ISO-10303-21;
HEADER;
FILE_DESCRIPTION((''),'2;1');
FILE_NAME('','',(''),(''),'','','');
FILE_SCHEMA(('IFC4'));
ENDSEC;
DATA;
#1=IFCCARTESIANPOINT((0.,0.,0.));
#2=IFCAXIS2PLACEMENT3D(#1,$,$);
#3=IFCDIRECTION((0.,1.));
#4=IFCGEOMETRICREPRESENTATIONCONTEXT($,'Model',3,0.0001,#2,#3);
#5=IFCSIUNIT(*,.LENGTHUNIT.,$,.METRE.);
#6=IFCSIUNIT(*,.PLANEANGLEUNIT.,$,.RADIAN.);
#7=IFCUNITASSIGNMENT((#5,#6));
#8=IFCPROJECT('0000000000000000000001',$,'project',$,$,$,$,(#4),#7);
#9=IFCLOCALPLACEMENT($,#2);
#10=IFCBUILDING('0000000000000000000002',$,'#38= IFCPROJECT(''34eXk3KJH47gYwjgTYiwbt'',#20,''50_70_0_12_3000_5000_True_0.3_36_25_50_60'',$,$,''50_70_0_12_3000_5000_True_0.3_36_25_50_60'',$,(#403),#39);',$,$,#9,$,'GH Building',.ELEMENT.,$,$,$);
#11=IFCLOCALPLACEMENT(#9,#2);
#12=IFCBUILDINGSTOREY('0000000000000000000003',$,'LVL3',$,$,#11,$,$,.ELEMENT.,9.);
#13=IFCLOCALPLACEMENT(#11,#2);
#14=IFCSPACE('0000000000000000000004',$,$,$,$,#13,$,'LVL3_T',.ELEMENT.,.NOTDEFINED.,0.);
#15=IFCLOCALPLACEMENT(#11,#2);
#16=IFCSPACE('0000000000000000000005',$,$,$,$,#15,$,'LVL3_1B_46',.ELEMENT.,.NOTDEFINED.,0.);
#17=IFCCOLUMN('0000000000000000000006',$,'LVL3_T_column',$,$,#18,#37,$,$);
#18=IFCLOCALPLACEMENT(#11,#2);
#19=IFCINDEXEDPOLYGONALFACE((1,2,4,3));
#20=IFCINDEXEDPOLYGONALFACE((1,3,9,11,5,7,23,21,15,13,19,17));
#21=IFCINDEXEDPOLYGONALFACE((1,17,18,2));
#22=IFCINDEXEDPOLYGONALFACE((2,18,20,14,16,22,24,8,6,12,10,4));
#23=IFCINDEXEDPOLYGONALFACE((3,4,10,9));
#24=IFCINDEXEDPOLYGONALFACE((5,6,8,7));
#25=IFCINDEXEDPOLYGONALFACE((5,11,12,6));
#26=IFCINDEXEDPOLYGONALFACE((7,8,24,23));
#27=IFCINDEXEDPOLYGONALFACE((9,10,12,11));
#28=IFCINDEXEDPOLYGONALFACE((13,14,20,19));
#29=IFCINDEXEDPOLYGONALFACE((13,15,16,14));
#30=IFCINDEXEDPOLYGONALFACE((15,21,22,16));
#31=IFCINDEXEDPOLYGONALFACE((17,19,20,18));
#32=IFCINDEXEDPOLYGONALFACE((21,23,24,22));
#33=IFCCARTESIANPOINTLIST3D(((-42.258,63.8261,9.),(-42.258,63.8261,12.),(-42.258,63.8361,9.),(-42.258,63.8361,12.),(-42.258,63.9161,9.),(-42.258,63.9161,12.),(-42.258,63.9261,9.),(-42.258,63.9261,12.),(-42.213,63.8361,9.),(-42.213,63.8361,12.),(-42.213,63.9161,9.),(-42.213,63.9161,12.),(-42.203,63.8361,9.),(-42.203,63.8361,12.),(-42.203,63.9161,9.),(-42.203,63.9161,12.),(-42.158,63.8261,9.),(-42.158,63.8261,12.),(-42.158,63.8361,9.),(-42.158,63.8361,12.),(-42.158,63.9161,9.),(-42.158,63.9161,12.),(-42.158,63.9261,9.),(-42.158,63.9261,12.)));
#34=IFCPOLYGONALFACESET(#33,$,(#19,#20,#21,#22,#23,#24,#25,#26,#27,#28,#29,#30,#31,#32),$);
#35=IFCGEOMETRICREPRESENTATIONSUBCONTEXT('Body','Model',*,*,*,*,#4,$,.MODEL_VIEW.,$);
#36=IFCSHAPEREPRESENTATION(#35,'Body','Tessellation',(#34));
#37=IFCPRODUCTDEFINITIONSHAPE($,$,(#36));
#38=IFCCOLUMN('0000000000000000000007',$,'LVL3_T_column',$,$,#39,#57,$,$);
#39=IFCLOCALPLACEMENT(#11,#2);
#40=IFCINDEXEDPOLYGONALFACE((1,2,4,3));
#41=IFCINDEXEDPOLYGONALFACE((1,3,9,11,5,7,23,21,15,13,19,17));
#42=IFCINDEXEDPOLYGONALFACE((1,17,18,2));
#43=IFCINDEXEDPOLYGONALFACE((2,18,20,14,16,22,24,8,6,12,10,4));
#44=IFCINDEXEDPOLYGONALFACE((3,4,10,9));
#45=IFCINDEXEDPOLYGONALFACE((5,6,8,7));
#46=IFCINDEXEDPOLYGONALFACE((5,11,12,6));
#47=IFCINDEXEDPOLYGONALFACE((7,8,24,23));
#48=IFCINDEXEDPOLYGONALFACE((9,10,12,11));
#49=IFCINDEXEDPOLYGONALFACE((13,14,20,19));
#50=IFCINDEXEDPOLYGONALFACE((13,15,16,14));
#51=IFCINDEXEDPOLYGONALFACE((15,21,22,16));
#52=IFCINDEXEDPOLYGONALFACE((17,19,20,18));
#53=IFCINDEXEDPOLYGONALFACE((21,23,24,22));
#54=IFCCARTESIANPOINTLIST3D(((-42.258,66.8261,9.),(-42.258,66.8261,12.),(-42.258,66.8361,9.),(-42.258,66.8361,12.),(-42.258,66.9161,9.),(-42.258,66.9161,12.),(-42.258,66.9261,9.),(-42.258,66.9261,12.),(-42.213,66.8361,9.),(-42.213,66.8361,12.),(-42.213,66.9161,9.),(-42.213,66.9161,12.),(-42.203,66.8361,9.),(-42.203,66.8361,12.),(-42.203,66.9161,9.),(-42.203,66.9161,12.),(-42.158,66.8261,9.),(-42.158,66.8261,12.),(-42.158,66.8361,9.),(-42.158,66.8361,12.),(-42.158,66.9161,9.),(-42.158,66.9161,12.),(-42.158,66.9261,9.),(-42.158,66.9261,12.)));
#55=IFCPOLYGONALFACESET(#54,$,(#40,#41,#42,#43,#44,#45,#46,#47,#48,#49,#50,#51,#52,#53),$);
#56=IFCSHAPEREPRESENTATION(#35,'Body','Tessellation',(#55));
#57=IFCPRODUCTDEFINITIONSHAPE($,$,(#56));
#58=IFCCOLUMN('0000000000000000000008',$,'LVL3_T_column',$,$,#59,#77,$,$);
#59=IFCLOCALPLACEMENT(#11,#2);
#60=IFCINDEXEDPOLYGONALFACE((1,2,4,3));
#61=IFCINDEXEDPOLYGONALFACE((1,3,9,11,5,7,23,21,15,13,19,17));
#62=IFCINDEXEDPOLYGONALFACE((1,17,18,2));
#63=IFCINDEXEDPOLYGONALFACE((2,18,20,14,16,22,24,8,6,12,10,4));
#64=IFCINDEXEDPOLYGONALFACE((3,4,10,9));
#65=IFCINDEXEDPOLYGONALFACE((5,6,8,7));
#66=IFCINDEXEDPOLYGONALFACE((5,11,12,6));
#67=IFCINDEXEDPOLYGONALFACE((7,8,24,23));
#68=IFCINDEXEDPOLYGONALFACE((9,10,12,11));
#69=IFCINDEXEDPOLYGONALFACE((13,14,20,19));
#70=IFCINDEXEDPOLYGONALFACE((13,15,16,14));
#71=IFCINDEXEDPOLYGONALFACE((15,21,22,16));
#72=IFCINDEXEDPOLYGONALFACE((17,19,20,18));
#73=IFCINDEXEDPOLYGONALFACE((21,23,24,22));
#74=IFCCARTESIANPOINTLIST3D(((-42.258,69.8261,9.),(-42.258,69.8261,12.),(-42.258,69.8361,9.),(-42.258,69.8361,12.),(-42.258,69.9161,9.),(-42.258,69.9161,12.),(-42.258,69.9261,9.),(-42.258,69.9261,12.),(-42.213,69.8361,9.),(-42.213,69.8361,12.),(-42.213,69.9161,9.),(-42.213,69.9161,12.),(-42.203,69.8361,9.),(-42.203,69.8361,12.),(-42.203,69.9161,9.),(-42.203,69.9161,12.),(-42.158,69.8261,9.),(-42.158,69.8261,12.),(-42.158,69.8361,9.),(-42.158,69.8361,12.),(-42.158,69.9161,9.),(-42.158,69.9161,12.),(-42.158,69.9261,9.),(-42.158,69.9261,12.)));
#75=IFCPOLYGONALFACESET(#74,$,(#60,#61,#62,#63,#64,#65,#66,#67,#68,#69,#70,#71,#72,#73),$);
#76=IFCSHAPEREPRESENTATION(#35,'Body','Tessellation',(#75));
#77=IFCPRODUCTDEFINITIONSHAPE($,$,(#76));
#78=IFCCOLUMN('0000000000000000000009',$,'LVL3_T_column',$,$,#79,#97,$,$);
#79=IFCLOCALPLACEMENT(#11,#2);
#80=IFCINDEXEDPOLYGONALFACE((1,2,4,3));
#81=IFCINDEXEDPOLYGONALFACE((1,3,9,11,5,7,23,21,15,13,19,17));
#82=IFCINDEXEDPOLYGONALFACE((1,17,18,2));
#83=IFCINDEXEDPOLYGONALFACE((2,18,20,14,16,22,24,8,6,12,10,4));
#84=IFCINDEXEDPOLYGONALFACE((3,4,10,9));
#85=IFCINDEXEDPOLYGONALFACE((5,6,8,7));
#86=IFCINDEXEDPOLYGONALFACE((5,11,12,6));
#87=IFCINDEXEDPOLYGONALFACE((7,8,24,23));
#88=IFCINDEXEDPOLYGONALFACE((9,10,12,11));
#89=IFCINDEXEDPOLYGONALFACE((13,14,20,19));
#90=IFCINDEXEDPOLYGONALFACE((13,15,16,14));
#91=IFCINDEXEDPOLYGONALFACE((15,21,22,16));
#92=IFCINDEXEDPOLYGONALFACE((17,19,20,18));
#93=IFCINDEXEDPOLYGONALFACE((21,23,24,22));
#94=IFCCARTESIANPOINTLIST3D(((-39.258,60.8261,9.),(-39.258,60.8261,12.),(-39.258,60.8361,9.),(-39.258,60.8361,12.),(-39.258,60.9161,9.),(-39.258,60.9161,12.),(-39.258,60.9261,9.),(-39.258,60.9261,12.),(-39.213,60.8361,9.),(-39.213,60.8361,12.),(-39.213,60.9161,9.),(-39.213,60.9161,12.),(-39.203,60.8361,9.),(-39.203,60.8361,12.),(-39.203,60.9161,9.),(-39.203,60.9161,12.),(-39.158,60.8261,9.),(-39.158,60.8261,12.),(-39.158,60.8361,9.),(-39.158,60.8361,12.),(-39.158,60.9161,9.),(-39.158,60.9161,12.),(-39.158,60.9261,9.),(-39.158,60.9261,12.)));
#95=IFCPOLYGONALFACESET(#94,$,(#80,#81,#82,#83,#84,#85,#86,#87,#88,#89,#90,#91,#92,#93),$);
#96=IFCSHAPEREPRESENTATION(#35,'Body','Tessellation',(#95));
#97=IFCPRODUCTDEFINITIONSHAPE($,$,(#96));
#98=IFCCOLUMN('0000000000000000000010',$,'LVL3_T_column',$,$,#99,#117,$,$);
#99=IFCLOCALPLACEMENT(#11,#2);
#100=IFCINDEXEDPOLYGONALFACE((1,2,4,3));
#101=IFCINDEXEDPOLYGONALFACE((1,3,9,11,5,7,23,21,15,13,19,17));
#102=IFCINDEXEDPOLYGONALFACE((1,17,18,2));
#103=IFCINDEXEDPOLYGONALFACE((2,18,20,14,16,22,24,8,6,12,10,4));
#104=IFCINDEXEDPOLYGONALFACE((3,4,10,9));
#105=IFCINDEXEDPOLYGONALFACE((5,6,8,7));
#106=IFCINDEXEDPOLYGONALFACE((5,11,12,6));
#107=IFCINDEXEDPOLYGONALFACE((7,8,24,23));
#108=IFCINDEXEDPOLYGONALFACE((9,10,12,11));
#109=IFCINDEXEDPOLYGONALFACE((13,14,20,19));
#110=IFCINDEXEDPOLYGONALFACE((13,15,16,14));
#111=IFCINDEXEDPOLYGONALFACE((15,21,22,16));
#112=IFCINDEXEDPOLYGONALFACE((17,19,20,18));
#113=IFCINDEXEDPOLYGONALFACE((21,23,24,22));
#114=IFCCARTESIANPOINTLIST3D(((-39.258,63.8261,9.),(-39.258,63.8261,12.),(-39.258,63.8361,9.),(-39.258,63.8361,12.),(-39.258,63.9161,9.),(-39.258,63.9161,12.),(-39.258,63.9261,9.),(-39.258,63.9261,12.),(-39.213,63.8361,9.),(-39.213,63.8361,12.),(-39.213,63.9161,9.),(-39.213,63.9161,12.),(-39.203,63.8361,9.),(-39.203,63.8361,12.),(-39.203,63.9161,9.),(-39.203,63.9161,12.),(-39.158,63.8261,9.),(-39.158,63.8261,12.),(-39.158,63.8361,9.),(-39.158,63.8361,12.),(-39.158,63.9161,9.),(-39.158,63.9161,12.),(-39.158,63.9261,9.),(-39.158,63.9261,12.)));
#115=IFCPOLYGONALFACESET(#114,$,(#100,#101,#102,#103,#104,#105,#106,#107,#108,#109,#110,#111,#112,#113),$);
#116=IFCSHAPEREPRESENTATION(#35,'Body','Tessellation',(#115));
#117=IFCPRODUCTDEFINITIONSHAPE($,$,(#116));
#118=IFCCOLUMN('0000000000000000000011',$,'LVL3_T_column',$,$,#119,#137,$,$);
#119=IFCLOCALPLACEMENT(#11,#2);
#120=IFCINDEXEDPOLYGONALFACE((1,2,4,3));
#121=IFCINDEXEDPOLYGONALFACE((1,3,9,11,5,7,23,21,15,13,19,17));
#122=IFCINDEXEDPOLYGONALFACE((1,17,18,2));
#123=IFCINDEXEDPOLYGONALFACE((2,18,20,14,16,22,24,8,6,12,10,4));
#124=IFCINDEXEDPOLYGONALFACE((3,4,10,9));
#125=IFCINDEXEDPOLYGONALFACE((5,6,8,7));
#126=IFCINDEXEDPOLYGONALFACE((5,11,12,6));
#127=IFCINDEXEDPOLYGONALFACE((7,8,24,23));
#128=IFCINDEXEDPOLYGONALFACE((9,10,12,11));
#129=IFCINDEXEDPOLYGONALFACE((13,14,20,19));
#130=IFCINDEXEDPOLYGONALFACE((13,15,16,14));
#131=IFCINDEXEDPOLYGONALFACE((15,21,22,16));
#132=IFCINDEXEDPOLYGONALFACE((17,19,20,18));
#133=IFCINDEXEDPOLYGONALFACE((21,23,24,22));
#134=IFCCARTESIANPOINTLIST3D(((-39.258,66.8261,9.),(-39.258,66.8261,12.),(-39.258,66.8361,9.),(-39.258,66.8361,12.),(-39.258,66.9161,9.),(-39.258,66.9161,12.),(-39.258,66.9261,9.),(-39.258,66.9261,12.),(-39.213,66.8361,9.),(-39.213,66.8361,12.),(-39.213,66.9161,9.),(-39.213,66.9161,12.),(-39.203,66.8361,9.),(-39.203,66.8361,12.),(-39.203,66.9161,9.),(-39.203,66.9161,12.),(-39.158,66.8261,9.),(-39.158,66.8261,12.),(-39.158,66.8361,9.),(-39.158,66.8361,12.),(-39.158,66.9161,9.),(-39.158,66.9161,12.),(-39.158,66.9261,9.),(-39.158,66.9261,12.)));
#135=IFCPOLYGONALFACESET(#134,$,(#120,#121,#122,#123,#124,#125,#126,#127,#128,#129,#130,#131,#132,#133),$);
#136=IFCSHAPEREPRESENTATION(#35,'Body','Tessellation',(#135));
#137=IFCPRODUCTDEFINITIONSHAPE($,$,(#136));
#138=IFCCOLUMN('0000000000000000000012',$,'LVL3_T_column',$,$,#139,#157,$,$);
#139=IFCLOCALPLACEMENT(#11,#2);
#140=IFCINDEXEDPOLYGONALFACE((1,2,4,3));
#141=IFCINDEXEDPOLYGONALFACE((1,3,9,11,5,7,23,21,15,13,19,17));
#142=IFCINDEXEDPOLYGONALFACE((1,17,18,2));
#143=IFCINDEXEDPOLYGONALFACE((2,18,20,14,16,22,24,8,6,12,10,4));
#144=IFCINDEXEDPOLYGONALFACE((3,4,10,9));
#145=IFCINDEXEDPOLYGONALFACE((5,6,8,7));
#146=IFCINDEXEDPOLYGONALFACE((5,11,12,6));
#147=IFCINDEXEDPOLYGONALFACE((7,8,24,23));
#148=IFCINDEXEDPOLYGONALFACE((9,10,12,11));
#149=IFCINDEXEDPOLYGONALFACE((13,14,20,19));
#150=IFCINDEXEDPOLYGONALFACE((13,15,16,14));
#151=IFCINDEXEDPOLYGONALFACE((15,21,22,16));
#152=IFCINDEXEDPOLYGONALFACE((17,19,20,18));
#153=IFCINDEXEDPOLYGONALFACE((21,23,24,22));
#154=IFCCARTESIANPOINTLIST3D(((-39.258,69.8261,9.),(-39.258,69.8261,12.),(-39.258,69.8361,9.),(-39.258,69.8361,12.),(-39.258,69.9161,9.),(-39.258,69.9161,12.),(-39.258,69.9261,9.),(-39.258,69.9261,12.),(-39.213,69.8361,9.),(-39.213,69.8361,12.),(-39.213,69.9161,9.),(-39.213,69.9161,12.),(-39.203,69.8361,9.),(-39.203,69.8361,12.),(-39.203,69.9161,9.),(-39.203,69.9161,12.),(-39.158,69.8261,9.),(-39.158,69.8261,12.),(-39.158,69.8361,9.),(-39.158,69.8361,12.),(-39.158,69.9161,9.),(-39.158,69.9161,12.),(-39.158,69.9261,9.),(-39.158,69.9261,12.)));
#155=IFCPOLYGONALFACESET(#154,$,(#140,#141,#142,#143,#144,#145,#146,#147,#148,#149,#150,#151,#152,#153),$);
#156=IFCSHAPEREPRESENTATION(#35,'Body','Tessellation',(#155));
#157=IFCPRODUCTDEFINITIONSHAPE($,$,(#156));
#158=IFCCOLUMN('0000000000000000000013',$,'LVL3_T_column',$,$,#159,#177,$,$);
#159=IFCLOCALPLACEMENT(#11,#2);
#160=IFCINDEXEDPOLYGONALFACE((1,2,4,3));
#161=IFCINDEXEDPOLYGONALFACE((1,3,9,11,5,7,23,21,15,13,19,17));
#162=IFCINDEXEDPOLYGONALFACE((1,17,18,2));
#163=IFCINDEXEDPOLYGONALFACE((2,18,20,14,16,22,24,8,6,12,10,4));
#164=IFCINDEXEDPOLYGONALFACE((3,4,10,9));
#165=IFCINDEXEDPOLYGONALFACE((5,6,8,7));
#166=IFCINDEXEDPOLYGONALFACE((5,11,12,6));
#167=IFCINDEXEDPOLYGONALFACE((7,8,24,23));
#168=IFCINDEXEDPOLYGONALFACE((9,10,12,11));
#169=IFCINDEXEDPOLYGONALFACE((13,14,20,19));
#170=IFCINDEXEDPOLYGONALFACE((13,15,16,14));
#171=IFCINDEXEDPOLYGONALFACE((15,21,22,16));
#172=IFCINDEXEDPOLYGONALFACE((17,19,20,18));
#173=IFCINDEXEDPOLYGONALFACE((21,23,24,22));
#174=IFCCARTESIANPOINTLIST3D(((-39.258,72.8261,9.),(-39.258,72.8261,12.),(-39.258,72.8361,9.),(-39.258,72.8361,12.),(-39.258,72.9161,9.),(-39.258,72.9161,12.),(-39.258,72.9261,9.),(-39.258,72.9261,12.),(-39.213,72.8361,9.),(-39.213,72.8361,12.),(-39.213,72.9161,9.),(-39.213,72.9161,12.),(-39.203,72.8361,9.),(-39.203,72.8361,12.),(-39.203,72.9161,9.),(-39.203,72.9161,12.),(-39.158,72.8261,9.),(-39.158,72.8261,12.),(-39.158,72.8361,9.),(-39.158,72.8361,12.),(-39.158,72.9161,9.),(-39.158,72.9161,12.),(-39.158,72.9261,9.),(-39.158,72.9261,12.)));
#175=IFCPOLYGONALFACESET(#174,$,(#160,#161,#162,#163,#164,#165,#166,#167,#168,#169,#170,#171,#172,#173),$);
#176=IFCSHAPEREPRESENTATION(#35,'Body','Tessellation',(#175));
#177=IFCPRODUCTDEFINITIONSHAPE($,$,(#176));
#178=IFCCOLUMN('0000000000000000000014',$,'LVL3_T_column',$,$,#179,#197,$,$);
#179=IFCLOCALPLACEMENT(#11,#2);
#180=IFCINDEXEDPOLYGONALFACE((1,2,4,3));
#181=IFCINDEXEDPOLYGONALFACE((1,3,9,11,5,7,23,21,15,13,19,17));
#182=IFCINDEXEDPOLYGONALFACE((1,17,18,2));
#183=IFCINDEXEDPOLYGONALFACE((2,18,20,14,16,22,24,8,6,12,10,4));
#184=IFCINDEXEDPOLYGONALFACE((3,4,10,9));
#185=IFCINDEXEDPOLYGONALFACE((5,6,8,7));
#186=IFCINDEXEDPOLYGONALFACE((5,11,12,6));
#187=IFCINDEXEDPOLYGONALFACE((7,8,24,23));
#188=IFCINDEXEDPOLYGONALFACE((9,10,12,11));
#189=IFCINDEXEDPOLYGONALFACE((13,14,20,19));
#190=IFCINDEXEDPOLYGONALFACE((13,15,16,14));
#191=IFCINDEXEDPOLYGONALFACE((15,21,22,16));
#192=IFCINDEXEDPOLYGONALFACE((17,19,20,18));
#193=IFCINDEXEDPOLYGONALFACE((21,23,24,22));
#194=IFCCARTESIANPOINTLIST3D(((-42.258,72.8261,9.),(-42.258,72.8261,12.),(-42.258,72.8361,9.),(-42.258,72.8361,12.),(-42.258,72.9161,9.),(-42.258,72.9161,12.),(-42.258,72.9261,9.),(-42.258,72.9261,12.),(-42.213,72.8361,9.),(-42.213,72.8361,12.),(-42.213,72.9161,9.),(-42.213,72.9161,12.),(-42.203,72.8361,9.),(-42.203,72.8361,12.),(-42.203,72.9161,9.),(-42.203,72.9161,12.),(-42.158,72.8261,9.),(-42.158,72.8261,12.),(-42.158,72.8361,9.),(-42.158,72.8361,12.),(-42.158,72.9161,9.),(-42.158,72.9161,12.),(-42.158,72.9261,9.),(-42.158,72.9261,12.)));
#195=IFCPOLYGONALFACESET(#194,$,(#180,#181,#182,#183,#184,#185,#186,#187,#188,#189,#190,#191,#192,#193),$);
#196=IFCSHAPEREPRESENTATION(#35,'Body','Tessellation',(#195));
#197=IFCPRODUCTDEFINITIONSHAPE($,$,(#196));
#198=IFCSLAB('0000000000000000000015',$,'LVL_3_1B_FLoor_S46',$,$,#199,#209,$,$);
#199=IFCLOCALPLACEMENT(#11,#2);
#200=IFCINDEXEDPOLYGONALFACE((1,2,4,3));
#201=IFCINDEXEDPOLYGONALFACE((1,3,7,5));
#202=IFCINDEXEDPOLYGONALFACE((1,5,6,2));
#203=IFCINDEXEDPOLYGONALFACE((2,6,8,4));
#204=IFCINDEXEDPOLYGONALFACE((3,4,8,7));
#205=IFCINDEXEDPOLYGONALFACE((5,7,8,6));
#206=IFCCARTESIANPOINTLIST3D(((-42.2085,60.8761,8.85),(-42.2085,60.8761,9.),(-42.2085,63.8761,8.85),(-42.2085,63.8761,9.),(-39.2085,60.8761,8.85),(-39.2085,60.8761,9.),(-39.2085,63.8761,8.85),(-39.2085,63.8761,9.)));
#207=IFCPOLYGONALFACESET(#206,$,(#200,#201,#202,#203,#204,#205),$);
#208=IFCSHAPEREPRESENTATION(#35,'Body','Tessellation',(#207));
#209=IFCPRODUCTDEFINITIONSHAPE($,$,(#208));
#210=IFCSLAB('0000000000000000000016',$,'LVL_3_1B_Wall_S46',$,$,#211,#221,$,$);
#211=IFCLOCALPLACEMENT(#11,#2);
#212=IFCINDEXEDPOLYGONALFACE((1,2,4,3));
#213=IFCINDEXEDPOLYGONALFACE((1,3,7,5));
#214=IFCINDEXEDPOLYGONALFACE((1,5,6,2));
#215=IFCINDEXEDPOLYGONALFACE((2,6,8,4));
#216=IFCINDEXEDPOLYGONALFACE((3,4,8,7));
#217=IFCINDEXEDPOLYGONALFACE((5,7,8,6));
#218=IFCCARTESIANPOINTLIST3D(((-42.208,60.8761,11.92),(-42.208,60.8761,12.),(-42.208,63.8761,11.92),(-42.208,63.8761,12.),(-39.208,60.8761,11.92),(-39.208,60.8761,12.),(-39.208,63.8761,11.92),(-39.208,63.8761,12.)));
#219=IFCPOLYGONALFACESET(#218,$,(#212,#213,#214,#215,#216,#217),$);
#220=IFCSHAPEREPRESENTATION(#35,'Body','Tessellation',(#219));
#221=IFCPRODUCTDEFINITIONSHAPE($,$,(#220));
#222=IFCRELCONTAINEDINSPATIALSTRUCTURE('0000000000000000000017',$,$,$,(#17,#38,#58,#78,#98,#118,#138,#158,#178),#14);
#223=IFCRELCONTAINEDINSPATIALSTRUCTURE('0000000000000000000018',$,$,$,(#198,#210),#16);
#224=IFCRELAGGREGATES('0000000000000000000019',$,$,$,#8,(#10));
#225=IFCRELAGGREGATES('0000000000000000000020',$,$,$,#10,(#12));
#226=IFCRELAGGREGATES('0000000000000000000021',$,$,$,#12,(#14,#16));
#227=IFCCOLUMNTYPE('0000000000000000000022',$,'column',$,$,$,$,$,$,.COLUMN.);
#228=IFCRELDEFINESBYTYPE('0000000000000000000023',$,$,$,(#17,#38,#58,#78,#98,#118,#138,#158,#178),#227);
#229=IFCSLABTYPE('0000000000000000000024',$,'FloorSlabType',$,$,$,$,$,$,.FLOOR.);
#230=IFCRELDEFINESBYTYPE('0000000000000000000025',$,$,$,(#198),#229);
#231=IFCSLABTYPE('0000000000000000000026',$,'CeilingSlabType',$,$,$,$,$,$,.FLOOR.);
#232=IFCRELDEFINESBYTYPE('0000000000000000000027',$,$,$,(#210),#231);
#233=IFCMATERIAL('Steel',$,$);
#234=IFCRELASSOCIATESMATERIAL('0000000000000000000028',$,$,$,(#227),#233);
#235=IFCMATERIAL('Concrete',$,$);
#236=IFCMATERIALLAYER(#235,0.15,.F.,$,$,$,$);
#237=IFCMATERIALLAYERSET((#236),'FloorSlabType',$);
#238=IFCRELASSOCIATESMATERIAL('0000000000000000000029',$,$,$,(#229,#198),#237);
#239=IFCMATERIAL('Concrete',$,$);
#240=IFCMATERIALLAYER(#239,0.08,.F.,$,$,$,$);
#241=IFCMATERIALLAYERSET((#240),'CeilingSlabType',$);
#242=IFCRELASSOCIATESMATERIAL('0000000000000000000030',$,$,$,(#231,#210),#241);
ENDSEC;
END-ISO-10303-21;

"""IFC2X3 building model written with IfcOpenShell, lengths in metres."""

from ifc_helpers import new_model, si_unit, direction, frame, frame_2d, origin, origin_2d, place, context, subcontext, project, spatial, rectangle, i_section, extrude, material, layer, layer_set, layer_usage, type_object, element, save


model = new_model("IFC2X3")

# Units and contexts
model_context = context("Model", 3, precision=0.0001, world=origin(), true_north=direction((0.0, 1.0)))
body_context = subcontext(model_context, "Body", "Model", "MODEL_VIEW")
ifc_project = project(units=[si_unit("LENGTHUNIT", "METRE"), si_unit("PLANEANGLEUNIT", "RADIAN")], contexts=[model_context])

# Building, storey, space
building_placement = place(None, origin())
building = spatial("IfcBuilding", under=ifc_project, at=building_placement, Name="#38= IFCPROJECT('34eXk3KJH47gYwjgTYiwbt',#20,'50_70_0_12_3000_5000_True_0.3_36_25_50_60',$,$,'50_70_0_12_3000_5000_True_0.3_36_25_50_60',$,(#403),#39);", LongName="GH Building", CompositionType="ELEMENT")
storey_placement = place(building_placement, origin())
storey = spatial("IfcBuildingStorey", under=building, at=storey_placement, Name="LVL3", CompositionType="ELEMENT", Elevation=9.0)
space_1_placement = place(storey_placement, origin())
space_1 = spatial("IfcSpace", under=storey, at=space_1_placement, LongName="LVL3_T", CompositionType="ELEMENT", InteriorOrExteriorSpace="NOTDEFINED", ElevationWithFlooring=0.0)

# Columns
ifc_material_1 = material(Name="Steel")
column_type = type_object("IfcColumnType", Name="column", PredefinedType="COLUMN", material=ifc_material_1)
for number, where, name in (
    (1, (-42.208, 63.8761, 9.0), "LVL3_T_column"),
    (2, (-42.208, 66.8761, 9.0), "LVL3_T_column"),
    (3, (-42.208, 69.8761, 9.0), "LVL3_T_column"),
    (4, (-39.208, 60.8761, 9.0), "LVL3_T_column"),
    (5, (-39.208, 63.8761, 9.0), "LVL3_T_column"),
    (6, (-39.208, 66.8761, 9.0), "LVL3_T_column"),
    (7, (-39.208, 69.8761, 9.0), "LVL3_T_column"),
    (8, (-39.208, 72.8761, 9.0), "LVL3_T_column"),
    (9, (-42.208, 72.8761, 9.0), "LVL3_T_column"),
):
    element("IfcColumn", number, at=place(space_1_placement, frame(where)), inside=space_1, type_object=column_type, Name=name, context=body_context, shape_type="SweptSolid", body=[
        extrude(i_section(OverallWidth=0.1, OverallDepth=0.1, WebThickness=0.01, FlangeThickness=0.01, at=origin_2d()), origin(), (0.0, 0.0, 1.0), 3.0),
    ])

# Shared definitions
space_2_placement = place(storey_placement, origin())
space_2 = spatial("IfcSpace", under=storey, at=space_2_placement, LongName="LVL3_1B_46", CompositionType="ELEMENT", InteriorOrExteriorSpace="NOTDEFINED", ElevationWithFlooring=0.0)

# Slabs
ifc_material_2 = material(Name="Concrete")
ifc_layer_1 = layer(ifc_material_2, 0.15, ventilated=False)
ifc_layer_set_1 = layer_set([ifc_layer_1], Name="FloorSlabType")
ifc_layer_usage_1 = layer_usage(ifc_layer_set_1, "AXIS3", "NEGATIVE", -0.15)
slab_type_1 = type_object("IfcSlabType", Name="FloorSlabType", PredefinedType="FLOOR", material=ifc_layer_set_1)
slab_1_placement = place(space_2_placement, frame((-42.2085, 63.8761, 8.85), z_axis=(0.0, 0.0, 1.0), x_axis=(0.0, -1.0, 0.0)))
element("IfcSlab", 10, at=slab_1_placement, inside=space_2, type_object=slab_type_1, material=ifc_layer_usage_1, Name="LVL_3_1B_FLoor_S46", context=body_context, shape_type="SweptSolid", body=[
    extrude(rectangle(XDim=3.0, YDim=3.0, at=frame_2d((1.5, 1.5))), origin(), (0.0, 0.0, 1.0), 0.15),
])
ifc_material_3 = material(Name="Concrete")
ifc_layer_2 = layer(ifc_material_3, 0.08, ventilated=False)
ifc_layer_set_2 = layer_set([ifc_layer_2], Name="CeilingSlabType")
ifc_layer_usage_2 = layer_usage(ifc_layer_set_2, "AXIS3", "NEGATIVE", -0.08)
slab_type_2 = type_object("IfcSlabType", Name="CeilingSlabType", PredefinedType="FLOOR", material=ifc_layer_set_2)
slab_2_placement = place(space_2_placement, frame((-42.208, 63.8761, 11.92), z_axis=(0.0, 0.0, 1.0), x_axis=(0.0, -1.0, 0.0)))
element("IfcSlab", 11, at=slab_2_placement, inside=space_2, type_object=slab_type_2, material=ifc_layer_usage_2, Name="LVL_3_1B_Wall_S46", context=body_context, shape_type="SweptSolid", body=[
    extrude(rectangle(XDim=3.0, YDim=3.0, at=frame_2d((1.5, 1.5))), origin(), (0.0, 0.0, 1.0), 0.08),
])

save(model, "model.ifc")
